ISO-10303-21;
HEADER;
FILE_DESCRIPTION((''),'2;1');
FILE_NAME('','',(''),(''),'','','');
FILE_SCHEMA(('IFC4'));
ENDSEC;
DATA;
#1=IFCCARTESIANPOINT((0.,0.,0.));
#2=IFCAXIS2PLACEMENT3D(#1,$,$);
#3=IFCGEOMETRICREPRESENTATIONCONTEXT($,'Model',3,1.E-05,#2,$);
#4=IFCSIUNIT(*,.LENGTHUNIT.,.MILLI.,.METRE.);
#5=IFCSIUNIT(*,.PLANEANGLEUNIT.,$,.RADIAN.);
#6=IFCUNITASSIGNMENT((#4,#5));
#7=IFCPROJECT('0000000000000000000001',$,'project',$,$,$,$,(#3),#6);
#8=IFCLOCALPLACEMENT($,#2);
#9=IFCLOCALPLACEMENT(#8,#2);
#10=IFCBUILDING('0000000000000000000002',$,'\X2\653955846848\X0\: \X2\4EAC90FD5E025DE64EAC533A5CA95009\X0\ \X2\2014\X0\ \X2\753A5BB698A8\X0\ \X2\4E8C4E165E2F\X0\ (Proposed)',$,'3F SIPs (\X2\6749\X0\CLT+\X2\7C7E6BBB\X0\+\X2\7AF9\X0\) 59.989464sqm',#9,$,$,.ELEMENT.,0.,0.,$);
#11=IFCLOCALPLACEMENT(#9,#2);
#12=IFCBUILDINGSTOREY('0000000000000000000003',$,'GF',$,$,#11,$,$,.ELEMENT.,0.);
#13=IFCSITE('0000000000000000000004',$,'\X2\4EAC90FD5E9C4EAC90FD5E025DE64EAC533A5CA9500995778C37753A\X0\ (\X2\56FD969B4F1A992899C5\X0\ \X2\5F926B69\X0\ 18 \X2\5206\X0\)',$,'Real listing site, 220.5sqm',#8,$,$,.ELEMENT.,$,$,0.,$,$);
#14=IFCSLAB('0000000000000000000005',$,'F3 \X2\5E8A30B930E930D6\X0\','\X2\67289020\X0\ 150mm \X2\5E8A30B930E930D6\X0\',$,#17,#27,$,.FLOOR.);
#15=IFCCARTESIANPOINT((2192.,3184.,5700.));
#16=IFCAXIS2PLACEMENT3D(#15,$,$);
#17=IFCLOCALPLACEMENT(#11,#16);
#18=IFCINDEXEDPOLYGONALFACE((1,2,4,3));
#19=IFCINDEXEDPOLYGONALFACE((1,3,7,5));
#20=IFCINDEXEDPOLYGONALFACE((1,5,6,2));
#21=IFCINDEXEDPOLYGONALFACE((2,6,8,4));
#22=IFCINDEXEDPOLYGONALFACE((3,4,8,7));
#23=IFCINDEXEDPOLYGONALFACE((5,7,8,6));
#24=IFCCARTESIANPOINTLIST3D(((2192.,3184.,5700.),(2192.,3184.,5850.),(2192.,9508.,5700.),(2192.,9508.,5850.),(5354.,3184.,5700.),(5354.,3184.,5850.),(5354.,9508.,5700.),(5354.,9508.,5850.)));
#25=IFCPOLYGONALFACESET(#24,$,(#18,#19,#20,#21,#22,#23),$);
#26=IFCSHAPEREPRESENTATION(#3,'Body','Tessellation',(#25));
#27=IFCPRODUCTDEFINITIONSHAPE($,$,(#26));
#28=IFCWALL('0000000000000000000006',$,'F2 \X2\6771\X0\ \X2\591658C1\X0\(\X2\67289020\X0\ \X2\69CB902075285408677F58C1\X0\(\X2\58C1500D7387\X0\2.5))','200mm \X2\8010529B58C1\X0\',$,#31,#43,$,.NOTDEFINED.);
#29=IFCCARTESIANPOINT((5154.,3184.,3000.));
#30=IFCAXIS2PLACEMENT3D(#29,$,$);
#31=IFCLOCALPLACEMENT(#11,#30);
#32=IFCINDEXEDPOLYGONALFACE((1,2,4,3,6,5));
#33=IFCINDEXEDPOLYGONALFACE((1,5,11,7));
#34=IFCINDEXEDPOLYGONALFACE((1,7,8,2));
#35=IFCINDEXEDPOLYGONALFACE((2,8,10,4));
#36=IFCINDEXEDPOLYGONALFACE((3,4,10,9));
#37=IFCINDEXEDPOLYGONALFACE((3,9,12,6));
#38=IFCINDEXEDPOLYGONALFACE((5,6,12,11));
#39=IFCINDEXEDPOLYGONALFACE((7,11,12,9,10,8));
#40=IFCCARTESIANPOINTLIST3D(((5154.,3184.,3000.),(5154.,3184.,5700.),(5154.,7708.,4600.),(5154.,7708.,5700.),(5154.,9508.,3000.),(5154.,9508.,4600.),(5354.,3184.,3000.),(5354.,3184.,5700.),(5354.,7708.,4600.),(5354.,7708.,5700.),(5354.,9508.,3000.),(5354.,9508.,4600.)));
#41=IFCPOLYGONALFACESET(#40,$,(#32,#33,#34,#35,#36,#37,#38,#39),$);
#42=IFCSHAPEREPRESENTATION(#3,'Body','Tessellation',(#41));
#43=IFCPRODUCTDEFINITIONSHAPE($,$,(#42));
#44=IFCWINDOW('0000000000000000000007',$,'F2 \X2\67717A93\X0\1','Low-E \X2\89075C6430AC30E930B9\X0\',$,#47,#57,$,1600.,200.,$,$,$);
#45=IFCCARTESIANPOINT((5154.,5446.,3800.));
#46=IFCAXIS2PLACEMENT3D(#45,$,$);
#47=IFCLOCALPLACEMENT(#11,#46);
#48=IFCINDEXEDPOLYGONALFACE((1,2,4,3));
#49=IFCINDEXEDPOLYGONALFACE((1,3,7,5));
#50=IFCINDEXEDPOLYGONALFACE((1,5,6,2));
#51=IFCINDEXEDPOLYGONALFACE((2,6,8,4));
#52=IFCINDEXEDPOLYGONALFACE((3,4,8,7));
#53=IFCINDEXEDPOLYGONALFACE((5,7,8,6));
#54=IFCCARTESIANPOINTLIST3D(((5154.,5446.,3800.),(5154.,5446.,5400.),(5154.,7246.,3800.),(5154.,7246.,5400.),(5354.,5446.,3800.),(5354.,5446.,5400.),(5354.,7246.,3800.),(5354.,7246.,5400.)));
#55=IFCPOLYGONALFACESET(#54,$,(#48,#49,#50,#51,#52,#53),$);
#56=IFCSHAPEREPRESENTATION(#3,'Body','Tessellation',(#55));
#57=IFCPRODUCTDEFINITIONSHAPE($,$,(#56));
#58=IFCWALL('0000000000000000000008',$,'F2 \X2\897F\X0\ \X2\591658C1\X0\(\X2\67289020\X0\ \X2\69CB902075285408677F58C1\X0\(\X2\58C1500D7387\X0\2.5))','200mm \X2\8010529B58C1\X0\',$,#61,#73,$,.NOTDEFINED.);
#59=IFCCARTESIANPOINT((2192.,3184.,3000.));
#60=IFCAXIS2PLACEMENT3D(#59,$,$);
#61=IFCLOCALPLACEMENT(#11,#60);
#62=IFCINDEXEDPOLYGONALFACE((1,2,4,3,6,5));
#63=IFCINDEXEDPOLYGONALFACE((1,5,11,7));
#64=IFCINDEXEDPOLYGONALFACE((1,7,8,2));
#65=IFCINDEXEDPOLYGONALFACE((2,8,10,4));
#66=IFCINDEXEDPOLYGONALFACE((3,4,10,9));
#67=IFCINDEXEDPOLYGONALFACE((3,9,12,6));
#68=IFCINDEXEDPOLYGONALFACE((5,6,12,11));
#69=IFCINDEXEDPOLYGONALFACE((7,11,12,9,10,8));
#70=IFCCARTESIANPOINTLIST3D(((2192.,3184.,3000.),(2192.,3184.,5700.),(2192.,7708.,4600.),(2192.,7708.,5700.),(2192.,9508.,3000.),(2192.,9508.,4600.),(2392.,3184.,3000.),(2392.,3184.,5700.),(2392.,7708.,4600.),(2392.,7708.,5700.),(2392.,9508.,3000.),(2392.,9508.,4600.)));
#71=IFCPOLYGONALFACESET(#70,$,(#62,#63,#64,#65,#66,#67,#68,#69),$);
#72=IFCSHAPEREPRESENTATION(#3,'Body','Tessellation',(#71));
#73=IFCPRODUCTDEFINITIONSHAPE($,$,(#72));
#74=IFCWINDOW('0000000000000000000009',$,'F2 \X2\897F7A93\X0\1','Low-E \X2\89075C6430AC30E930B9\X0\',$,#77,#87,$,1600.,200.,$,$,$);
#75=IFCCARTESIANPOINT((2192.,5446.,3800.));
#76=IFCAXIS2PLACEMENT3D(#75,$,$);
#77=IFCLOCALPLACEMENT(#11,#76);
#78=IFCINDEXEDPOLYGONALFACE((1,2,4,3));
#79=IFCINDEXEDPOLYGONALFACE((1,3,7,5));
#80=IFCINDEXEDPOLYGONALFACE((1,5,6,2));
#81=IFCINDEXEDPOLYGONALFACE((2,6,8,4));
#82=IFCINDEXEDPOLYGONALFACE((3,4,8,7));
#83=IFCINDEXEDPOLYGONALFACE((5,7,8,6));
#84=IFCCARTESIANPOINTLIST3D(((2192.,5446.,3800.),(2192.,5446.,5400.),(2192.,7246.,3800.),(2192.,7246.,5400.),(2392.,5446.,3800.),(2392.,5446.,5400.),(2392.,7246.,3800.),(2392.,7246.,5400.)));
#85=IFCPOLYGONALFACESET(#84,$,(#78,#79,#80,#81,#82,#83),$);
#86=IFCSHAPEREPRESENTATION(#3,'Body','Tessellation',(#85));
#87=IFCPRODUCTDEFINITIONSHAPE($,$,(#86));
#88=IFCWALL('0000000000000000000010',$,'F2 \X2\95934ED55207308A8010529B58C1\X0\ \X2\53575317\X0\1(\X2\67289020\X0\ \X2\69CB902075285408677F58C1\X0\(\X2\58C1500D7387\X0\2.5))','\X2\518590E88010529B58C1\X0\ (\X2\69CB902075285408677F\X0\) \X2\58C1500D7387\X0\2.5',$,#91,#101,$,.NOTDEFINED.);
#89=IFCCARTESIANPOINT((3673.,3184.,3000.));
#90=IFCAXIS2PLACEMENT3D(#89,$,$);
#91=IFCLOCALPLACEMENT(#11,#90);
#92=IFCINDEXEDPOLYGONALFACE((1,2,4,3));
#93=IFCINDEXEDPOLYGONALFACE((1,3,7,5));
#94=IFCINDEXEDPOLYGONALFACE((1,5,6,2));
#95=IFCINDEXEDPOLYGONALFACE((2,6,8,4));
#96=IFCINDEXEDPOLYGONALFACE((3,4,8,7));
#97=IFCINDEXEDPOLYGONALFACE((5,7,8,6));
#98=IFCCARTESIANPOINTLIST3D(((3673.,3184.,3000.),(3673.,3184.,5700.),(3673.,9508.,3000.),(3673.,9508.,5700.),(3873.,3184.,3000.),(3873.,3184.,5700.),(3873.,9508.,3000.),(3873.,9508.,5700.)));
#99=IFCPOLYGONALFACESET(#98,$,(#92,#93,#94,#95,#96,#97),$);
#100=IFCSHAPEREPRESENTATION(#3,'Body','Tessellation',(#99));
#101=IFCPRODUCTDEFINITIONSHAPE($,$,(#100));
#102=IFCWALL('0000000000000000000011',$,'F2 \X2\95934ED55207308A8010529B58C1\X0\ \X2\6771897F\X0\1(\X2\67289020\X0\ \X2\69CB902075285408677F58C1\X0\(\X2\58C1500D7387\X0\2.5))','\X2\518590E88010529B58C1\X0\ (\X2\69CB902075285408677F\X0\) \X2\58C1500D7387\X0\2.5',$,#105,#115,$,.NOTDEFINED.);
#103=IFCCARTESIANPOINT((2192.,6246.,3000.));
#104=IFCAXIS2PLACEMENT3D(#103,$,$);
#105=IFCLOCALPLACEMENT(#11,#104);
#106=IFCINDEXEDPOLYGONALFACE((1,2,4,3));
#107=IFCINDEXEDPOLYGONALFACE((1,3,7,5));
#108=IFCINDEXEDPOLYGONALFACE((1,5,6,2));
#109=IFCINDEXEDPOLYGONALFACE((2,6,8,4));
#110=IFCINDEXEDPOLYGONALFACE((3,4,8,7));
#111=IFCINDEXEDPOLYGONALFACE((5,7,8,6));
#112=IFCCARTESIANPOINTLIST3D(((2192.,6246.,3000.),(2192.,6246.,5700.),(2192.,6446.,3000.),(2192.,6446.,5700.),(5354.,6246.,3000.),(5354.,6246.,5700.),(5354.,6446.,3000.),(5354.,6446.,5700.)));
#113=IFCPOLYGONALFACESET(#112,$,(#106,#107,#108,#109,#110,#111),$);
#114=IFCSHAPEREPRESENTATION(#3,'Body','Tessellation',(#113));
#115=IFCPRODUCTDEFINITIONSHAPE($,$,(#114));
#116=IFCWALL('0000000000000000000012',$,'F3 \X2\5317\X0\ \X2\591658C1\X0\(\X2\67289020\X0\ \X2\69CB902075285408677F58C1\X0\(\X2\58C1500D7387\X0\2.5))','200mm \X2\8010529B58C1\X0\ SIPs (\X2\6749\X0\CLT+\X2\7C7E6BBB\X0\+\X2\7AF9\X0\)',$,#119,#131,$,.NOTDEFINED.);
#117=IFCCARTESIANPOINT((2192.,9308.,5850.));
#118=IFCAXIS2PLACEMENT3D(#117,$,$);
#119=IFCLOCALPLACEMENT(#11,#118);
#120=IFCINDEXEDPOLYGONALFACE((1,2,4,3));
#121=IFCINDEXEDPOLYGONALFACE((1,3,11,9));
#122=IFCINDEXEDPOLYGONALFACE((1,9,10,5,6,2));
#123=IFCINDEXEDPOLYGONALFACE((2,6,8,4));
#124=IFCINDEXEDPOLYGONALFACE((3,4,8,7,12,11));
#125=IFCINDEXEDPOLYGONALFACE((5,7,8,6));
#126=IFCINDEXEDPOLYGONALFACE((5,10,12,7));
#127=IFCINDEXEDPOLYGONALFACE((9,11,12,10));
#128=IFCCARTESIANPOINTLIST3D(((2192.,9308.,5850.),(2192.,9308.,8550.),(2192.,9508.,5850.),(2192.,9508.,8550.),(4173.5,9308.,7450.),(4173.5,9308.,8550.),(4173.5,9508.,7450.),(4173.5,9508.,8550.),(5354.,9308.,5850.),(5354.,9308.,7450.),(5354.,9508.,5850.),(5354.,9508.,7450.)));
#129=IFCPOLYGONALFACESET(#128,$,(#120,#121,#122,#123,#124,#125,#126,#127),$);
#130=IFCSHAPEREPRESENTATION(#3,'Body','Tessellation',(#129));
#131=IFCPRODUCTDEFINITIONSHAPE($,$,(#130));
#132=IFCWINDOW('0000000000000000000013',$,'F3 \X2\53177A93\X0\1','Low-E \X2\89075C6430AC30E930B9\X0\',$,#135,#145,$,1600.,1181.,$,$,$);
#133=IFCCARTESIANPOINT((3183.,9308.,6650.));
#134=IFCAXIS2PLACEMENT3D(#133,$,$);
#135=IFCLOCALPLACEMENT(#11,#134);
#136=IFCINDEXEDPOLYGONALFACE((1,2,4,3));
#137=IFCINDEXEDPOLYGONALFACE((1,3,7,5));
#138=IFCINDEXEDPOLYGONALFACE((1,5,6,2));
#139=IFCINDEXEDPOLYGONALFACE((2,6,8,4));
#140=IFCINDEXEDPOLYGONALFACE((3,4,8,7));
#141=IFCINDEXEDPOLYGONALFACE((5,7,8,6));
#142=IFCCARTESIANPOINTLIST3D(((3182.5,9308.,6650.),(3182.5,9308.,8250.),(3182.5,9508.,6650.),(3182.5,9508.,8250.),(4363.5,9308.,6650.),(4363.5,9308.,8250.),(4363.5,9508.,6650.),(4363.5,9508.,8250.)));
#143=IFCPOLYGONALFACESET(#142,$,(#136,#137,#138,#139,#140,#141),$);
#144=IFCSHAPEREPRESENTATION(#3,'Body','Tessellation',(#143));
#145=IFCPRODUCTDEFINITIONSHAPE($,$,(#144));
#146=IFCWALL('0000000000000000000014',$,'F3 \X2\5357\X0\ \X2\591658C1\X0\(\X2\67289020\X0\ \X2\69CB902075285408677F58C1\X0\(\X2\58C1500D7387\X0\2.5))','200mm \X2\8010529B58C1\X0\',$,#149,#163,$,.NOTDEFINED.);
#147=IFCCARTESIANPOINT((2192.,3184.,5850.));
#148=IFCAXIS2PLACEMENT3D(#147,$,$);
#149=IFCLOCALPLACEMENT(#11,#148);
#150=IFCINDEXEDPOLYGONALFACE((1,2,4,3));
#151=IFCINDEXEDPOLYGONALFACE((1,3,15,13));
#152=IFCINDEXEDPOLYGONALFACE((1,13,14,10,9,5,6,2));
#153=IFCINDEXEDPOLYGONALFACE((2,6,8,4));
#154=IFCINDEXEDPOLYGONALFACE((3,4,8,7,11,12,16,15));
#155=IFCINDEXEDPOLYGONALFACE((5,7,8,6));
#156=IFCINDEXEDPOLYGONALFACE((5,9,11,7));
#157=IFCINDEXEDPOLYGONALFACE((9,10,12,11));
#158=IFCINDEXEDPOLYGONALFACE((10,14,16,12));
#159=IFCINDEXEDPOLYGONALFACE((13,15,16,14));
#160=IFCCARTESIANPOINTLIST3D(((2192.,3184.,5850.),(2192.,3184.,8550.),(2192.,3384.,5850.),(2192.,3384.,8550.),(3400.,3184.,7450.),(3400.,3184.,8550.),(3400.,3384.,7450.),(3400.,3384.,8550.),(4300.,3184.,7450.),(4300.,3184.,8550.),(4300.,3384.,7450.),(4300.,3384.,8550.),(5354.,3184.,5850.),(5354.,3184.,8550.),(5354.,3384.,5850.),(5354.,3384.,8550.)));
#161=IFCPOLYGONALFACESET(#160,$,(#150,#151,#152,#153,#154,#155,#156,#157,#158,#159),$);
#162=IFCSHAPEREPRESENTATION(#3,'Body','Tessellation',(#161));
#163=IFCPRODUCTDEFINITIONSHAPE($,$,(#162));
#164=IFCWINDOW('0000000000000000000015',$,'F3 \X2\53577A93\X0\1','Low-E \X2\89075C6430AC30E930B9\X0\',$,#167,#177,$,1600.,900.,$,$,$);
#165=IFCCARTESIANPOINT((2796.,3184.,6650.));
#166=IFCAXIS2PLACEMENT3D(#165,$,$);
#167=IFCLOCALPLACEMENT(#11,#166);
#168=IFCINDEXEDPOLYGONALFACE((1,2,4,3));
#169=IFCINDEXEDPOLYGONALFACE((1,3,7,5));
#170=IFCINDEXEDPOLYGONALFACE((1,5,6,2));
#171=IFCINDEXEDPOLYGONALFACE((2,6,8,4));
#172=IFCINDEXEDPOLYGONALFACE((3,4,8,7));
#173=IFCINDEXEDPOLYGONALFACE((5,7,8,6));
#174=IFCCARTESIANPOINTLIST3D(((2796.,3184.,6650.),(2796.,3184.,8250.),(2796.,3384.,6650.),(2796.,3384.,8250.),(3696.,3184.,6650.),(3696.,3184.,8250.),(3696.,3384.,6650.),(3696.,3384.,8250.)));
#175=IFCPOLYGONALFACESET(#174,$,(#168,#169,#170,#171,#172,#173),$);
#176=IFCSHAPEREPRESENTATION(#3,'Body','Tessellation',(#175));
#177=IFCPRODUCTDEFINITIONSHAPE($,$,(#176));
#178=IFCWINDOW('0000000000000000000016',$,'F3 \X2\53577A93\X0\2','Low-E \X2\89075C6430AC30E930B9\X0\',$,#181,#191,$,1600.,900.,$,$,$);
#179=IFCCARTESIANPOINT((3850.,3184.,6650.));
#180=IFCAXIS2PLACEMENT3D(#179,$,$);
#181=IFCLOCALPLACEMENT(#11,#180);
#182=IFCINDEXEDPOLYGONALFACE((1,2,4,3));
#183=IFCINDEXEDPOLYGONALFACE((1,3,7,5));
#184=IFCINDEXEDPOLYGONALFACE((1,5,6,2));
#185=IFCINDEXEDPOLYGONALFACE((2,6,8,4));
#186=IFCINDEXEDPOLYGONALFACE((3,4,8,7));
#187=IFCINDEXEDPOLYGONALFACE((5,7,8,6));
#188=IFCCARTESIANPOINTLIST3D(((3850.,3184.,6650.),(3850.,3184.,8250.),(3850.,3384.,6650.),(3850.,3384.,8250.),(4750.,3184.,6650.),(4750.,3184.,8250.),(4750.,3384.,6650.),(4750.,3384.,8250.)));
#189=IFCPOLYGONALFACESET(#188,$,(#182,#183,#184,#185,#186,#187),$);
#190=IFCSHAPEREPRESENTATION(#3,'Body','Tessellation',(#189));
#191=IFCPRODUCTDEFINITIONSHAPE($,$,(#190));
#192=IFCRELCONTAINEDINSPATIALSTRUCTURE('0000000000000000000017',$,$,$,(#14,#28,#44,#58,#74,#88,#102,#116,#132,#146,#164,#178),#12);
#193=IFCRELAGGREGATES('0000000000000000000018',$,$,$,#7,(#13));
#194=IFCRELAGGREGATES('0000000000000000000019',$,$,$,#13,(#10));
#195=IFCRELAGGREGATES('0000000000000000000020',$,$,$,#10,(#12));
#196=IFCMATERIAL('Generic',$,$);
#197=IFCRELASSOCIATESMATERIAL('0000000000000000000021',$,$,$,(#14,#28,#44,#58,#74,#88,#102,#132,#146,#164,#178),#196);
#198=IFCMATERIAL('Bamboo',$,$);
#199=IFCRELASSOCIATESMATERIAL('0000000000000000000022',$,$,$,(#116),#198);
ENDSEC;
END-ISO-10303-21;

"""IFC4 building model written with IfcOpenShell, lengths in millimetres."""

from ifc_helpers import new_model, si_unit, frame, frame_2d, origin, place, context, project, spatial, rectangle, extrude, material, element, fill, save


model = new_model("IFC4")

# Units and contexts
model_context = context("Model", 3, precision=1e-05, world=origin())
ifc_project = project(units=[si_unit("LENGTHUNIT", "METRE", prefix="MILLI"), si_unit("PLANEANGLEUNIT", "RADIAN")], contexts=[model_context])

# Site, building, storey
site_placement = place(None, origin())
site = spatial("IfcSite", under=ifc_project, at=site_placement, Name="京都府京都市左京区岩倉長谷町 (国際会館駅 徒歩 18 分)", ObjectType="Real listing site, 220.5sqm", CompositionType="ELEMENT", RefElevation=0.0)
building_placement = place(site_placement, origin())
building = spatial("IfcBuilding", under=site, at=building_placement, Name="改善案: 京都市左京区岩倉 — 町家風 二世帯 (Proposed)", ObjectType="3F SIPs (杉CLT+籾殻+竹) 59.989464sqm", CompositionType="ELEMENT", ElevationOfRefHeight=0.0, ElevationOfTerrain=0.0)
storey_placement = place(building_placement, origin())
storey = spatial("IfcBuildingStorey", under=building, at=storey_placement, Name="GF", CompositionType="ELEMENT", Elevation=0.0)

# Slab
ifc_material_1 = material(Name="Generic")
slab_placement = place(storey_placement, frame((2192.0, 3184.0, 5700.0)))
element("IfcSlab", 1, at=slab_placement, inside=storey, material=ifc_material_1, Name="F3 床スラブ", Description="木造 150mm 床スラブ", PredefinedType="FLOOR", context=model_context, shape_type="SweptSolid", body=[
    extrude(rectangle(XDim=3162.0, YDim=6324.0, at=frame_2d((1581.0, 3162.0))), frame((2192.0, 3184.0, 5700.0)), (0.0, 0.0, 1.0), 150.0),
])

# Walls, openings, windows
wall_1_placement = place(storey_placement, frame((5154.0, 3184.0, 3000.0)))
wall_1 = element("IfcWall", 2, at=wall_1_placement, inside=storey, material=ifc_material_1, Name="F2 東 外壁(木造 構造用合板壁(壁倍率2.5))", Description="200mm 耐力壁", PredefinedType="NOTDEFINED", context=model_context, shape_type="SweptSolid", body=[
    extrude(rectangle(XDim=200.0, YDim=6324.0, at=frame_2d((100.0, 3162.0))), frame((5154.0, 3184.0, 3000.0)), (0.0, 0.0, 1.0), 2700.0),
])
opening_1_placement = place(storey_placement, frame((5154.0, 5446.0, 3800.0)))
opening_1 = element("IfcOpeningElement", 3, at=opening_1_placement, cuts=wall_1, PredefinedType="NOTDEFINED", context=model_context, shape_type="SweptSolid", body=[
    extrude(rectangle(XDim=200.0, YDim=1800.0, at=frame_2d((100.0, 900.0))), frame((5154.0, 5446.0, 3800.0)), (0.0, 0.0, 1.0), 1600.0),
])
window_1_placement = place(storey_placement, frame((5154.0, 5446.0, 3800.0)))
window_1 = element("IfcWindow", 4, at=window_1_placement, inside=storey, material=ifc_material_1, Name="F2 東窓1", Description="Low-E 複層ガラス", OverallHeight=1600.0, OverallWidth=200.0, context=model_context, shape_type="SweptSolid", body=[
    extrude(rectangle(XDim=200.0, YDim=1800.0, at=frame_2d((100.0, 900.0))), frame((5154.0, 5446.0, 3800.0)), (0.0, 0.0, 1.0), 1600.0),
])
fill(opening_1, window_1)
wall_2_placement = place(storey_placement, frame((2192.0, 3184.0, 3000.0)))
wall_2 = element("IfcWall", 5, at=wall_2_placement, inside=storey, material=ifc_material_1, Name="F2 西 外壁(木造 構造用合板壁(壁倍率2.5))", Description="200mm 耐力壁", PredefinedType="NOTDEFINED", context=model_context, shape_type="SweptSolid", body=[
    extrude(rectangle(XDim=200.0, YDim=6324.0, at=frame_2d((100.0, 3162.0))), frame((2192.0, 3184.0, 3000.0)), (0.0, 0.0, 1.0), 2700.0),
])
opening_2_placement = place(storey_placement, frame((2192.0, 5446.0, 3800.0)))
opening_2 = element("IfcOpeningElement", 6, at=opening_2_placement, cuts=wall_2, PredefinedType="NOTDEFINED", context=model_context, shape_type="SweptSolid", body=[
    extrude(rectangle(XDim=200.0, YDim=1800.0, at=frame_2d((100.0, 900.0))), frame((2192.0, 5446.0, 3800.0)), (0.0, 0.0, 1.0), 1600.0),
])
window_2_placement = place(storey_placement, frame((2192.0, 5446.0, 3800.0)))
window_2 = element("IfcWindow", 7, at=window_2_placement, inside=storey, material=ifc_material_1, Name="F2 西窓1", Description="Low-E 複層ガラス", OverallHeight=1600.0, OverallWidth=200.0, context=model_context, shape_type="SweptSolid", body=[
    extrude(rectangle(XDim=200.0, YDim=1800.0, at=frame_2d((100.0, 900.0))), frame((2192.0, 5446.0, 3800.0)), (0.0, 0.0, 1.0), 1600.0),
])
fill(opening_2, window_2)

# Walls
wall_3_placement = place(storey_placement, frame((3673.0, 3184.0, 3000.0)))
element("IfcWall", 8, at=wall_3_placement, inside=storey, material=ifc_material_1, Name="F2 間仕切り耐力壁 南北1(木造 構造用合板壁(壁倍率2.5))", Description="内部耐力壁 (構造用合板) 壁倍率2.5", PredefinedType="NOTDEFINED", context=model_context, shape_type="SweptSolid", body=[
    extrude(rectangle(XDim=200.0, YDim=6324.0, at=frame_2d((100.0, 3162.0))), frame((3673.0, 3184.0, 3000.0)), (0.0, 0.0, 1.0), 2700.0),
])
wall_4_placement = place(storey_placement, frame((2192.0, 6246.0, 3000.0)))
element("IfcWall", 9, at=wall_4_placement, inside=storey, material=ifc_material_1, Name="F2 間仕切り耐力壁 東西1(木造 構造用合板壁(壁倍率2.5))", Description="内部耐力壁 (構造用合板) 壁倍率2.5", PredefinedType="NOTDEFINED", context=model_context, shape_type="SweptSolid", body=[
    extrude(rectangle(XDim=3162.0, YDim=200.0, at=frame_2d((1581.0, 100.0))), frame((2192.0, 6246.0, 3000.0)), (0.0, 0.0, 1.0), 2700.0),
])

# Wall, opening, window
ifc_material_2 = material(Name="Bamboo")
wall_5_placement = place(storey_placement, frame((2192.0, 9308.0, 5850.0)))
wall_5 = element("IfcWall", 10, at=wall_5_placement, inside=storey, material=ifc_material_2, Name="F3 北 外壁(木造 構造用合板壁(壁倍率2.5))", Description="200mm 耐力壁 SIPs (杉CLT+籾殻+竹)", PredefinedType="NOTDEFINED", context=model_context, shape_type="SweptSolid", body=[
    extrude(rectangle(XDim=3162.0, YDim=200.0, at=frame_2d((1581.0, 100.0))), frame((2192.0, 9308.0, 5850.0)), (0.0, 0.0, 1.0), 2700.0),
])
opening_3_placement = place(storey_placement, frame((3183.0, 9308.0, 6650.0)))
opening_3 = element("IfcOpeningElement", 11, at=opening_3_placement, cuts=wall_5, PredefinedType="NOTDEFINED", context=model_context, shape_type="SweptSolid", body=[
    extrude(rectangle(XDim=1181.0, YDim=200.0, at=frame_2d((590.0, 100.0))), frame((3183.0, 9308.0, 6650.0)), (0.0, 0.0, 1.0), 1600.0),
])
window_3_placement = place(storey_placement, frame((3183.0, 9308.0, 6650.0)))
window_3 = element("IfcWindow", 12, at=window_3_placement, inside=storey, material=ifc_material_1, Name="F3 北窓1", Description="Low-E 複層ガラス", OverallHeight=1600.0, OverallWidth=1181.0, context=model_context, shape_type="SweptSolid", body=[
    extrude(rectangle(XDim=1181.0, YDim=200.0, at=frame_2d((590.0, 100.0))), frame((3183.0, 9308.0, 6650.0)), (0.0, 0.0, 1.0), 1600.0),
])
fill(opening_3, window_3)

# Wall, openings, windows
wall_6_placement = place(storey_placement, frame((2192.0, 3184.0, 5850.0)))
wall_6 = element("IfcWall", 13, at=wall_6_placement, inside=storey, material=ifc_material_1, Name="F3 南 外壁(木造 構造用合板壁(壁倍率2.5))", Description="200mm 耐力壁", PredefinedType="NOTDEFINED", context=model_context, shape_type="SweptSolid", body=[
    extrude(rectangle(XDim=3162.0, YDim=200.0, at=frame_2d((1581.0, 100.0))), frame((2192.0, 3184.0, 5850.0)), (0.0, 0.0, 1.0), 2700.0),
])
opening_4_placement = place(storey_placement, frame((2796.0, 3184.0, 6650.0)))
opening_4 = element("IfcOpeningElement", 14, at=opening_4_placement, cuts=wall_6, PredefinedType="NOTDEFINED", context=model_context, shape_type="SweptSolid", body=[
    extrude(rectangle(XDim=900.0, YDim=200.0, at=frame_2d((450.0, 100.0))), frame((2796.0, 3184.0, 6650.0)), (0.0, 0.0, 1.0), 1600.0),
])
opening_5_placement = place(storey_placement, frame((3850.0, 3184.0, 6650.0)))
opening_5 = element("IfcOpeningElement", 15, at=opening_5_placement, cuts=wall_6, PredefinedType="NOTDEFINED", context=model_context, shape_type="SweptSolid", body=[
    extrude(rectangle(XDim=900.0, YDim=200.0, at=frame_2d((450.0, 100.0))), frame((3850.0, 3184.0, 6650.0)), (0.0, 0.0, 1.0), 1600.0),
])
window_4_placement = place(storey_placement, frame((2796.0, 3184.0, 6650.0)))
window_4 = element("IfcWindow", 16, at=window_4_placement, inside=storey, material=ifc_material_1, Name="F3 南窓1", Description="Low-E 複層ガラス", OverallHeight=1600.0, OverallWidth=900.0, context=model_context, shape_type="SweptSolid", body=[
    extrude(rectangle(XDim=900.0, YDim=200.0, at=frame_2d((450.0, 100.0))), frame((2796.0, 3184.0, 6650.0)), (0.0, 0.0, 1.0), 1600.0),
])
fill(opening_4, window_4)
window_5_placement = place(storey_placement, frame((3850.0, 3184.0, 6650.0)))
window_5 = element("IfcWindow", 17, at=window_5_placement, inside=storey, material=ifc_material_1, Name="F3 南窓2", Description="Low-E 複層ガラス", OverallHeight=1600.0, OverallWidth=900.0, context=model_context, shape_type="SweptSolid", body=[
    extrude(rectangle(XDim=900.0, YDim=200.0, at=frame_2d((450.0, 100.0))), frame((3850.0, 3184.0, 6650.0)), (0.0, 0.0, 1.0), 1600.0),
])
fill(opening_5, window_5)

save(model, "model.ifc")
